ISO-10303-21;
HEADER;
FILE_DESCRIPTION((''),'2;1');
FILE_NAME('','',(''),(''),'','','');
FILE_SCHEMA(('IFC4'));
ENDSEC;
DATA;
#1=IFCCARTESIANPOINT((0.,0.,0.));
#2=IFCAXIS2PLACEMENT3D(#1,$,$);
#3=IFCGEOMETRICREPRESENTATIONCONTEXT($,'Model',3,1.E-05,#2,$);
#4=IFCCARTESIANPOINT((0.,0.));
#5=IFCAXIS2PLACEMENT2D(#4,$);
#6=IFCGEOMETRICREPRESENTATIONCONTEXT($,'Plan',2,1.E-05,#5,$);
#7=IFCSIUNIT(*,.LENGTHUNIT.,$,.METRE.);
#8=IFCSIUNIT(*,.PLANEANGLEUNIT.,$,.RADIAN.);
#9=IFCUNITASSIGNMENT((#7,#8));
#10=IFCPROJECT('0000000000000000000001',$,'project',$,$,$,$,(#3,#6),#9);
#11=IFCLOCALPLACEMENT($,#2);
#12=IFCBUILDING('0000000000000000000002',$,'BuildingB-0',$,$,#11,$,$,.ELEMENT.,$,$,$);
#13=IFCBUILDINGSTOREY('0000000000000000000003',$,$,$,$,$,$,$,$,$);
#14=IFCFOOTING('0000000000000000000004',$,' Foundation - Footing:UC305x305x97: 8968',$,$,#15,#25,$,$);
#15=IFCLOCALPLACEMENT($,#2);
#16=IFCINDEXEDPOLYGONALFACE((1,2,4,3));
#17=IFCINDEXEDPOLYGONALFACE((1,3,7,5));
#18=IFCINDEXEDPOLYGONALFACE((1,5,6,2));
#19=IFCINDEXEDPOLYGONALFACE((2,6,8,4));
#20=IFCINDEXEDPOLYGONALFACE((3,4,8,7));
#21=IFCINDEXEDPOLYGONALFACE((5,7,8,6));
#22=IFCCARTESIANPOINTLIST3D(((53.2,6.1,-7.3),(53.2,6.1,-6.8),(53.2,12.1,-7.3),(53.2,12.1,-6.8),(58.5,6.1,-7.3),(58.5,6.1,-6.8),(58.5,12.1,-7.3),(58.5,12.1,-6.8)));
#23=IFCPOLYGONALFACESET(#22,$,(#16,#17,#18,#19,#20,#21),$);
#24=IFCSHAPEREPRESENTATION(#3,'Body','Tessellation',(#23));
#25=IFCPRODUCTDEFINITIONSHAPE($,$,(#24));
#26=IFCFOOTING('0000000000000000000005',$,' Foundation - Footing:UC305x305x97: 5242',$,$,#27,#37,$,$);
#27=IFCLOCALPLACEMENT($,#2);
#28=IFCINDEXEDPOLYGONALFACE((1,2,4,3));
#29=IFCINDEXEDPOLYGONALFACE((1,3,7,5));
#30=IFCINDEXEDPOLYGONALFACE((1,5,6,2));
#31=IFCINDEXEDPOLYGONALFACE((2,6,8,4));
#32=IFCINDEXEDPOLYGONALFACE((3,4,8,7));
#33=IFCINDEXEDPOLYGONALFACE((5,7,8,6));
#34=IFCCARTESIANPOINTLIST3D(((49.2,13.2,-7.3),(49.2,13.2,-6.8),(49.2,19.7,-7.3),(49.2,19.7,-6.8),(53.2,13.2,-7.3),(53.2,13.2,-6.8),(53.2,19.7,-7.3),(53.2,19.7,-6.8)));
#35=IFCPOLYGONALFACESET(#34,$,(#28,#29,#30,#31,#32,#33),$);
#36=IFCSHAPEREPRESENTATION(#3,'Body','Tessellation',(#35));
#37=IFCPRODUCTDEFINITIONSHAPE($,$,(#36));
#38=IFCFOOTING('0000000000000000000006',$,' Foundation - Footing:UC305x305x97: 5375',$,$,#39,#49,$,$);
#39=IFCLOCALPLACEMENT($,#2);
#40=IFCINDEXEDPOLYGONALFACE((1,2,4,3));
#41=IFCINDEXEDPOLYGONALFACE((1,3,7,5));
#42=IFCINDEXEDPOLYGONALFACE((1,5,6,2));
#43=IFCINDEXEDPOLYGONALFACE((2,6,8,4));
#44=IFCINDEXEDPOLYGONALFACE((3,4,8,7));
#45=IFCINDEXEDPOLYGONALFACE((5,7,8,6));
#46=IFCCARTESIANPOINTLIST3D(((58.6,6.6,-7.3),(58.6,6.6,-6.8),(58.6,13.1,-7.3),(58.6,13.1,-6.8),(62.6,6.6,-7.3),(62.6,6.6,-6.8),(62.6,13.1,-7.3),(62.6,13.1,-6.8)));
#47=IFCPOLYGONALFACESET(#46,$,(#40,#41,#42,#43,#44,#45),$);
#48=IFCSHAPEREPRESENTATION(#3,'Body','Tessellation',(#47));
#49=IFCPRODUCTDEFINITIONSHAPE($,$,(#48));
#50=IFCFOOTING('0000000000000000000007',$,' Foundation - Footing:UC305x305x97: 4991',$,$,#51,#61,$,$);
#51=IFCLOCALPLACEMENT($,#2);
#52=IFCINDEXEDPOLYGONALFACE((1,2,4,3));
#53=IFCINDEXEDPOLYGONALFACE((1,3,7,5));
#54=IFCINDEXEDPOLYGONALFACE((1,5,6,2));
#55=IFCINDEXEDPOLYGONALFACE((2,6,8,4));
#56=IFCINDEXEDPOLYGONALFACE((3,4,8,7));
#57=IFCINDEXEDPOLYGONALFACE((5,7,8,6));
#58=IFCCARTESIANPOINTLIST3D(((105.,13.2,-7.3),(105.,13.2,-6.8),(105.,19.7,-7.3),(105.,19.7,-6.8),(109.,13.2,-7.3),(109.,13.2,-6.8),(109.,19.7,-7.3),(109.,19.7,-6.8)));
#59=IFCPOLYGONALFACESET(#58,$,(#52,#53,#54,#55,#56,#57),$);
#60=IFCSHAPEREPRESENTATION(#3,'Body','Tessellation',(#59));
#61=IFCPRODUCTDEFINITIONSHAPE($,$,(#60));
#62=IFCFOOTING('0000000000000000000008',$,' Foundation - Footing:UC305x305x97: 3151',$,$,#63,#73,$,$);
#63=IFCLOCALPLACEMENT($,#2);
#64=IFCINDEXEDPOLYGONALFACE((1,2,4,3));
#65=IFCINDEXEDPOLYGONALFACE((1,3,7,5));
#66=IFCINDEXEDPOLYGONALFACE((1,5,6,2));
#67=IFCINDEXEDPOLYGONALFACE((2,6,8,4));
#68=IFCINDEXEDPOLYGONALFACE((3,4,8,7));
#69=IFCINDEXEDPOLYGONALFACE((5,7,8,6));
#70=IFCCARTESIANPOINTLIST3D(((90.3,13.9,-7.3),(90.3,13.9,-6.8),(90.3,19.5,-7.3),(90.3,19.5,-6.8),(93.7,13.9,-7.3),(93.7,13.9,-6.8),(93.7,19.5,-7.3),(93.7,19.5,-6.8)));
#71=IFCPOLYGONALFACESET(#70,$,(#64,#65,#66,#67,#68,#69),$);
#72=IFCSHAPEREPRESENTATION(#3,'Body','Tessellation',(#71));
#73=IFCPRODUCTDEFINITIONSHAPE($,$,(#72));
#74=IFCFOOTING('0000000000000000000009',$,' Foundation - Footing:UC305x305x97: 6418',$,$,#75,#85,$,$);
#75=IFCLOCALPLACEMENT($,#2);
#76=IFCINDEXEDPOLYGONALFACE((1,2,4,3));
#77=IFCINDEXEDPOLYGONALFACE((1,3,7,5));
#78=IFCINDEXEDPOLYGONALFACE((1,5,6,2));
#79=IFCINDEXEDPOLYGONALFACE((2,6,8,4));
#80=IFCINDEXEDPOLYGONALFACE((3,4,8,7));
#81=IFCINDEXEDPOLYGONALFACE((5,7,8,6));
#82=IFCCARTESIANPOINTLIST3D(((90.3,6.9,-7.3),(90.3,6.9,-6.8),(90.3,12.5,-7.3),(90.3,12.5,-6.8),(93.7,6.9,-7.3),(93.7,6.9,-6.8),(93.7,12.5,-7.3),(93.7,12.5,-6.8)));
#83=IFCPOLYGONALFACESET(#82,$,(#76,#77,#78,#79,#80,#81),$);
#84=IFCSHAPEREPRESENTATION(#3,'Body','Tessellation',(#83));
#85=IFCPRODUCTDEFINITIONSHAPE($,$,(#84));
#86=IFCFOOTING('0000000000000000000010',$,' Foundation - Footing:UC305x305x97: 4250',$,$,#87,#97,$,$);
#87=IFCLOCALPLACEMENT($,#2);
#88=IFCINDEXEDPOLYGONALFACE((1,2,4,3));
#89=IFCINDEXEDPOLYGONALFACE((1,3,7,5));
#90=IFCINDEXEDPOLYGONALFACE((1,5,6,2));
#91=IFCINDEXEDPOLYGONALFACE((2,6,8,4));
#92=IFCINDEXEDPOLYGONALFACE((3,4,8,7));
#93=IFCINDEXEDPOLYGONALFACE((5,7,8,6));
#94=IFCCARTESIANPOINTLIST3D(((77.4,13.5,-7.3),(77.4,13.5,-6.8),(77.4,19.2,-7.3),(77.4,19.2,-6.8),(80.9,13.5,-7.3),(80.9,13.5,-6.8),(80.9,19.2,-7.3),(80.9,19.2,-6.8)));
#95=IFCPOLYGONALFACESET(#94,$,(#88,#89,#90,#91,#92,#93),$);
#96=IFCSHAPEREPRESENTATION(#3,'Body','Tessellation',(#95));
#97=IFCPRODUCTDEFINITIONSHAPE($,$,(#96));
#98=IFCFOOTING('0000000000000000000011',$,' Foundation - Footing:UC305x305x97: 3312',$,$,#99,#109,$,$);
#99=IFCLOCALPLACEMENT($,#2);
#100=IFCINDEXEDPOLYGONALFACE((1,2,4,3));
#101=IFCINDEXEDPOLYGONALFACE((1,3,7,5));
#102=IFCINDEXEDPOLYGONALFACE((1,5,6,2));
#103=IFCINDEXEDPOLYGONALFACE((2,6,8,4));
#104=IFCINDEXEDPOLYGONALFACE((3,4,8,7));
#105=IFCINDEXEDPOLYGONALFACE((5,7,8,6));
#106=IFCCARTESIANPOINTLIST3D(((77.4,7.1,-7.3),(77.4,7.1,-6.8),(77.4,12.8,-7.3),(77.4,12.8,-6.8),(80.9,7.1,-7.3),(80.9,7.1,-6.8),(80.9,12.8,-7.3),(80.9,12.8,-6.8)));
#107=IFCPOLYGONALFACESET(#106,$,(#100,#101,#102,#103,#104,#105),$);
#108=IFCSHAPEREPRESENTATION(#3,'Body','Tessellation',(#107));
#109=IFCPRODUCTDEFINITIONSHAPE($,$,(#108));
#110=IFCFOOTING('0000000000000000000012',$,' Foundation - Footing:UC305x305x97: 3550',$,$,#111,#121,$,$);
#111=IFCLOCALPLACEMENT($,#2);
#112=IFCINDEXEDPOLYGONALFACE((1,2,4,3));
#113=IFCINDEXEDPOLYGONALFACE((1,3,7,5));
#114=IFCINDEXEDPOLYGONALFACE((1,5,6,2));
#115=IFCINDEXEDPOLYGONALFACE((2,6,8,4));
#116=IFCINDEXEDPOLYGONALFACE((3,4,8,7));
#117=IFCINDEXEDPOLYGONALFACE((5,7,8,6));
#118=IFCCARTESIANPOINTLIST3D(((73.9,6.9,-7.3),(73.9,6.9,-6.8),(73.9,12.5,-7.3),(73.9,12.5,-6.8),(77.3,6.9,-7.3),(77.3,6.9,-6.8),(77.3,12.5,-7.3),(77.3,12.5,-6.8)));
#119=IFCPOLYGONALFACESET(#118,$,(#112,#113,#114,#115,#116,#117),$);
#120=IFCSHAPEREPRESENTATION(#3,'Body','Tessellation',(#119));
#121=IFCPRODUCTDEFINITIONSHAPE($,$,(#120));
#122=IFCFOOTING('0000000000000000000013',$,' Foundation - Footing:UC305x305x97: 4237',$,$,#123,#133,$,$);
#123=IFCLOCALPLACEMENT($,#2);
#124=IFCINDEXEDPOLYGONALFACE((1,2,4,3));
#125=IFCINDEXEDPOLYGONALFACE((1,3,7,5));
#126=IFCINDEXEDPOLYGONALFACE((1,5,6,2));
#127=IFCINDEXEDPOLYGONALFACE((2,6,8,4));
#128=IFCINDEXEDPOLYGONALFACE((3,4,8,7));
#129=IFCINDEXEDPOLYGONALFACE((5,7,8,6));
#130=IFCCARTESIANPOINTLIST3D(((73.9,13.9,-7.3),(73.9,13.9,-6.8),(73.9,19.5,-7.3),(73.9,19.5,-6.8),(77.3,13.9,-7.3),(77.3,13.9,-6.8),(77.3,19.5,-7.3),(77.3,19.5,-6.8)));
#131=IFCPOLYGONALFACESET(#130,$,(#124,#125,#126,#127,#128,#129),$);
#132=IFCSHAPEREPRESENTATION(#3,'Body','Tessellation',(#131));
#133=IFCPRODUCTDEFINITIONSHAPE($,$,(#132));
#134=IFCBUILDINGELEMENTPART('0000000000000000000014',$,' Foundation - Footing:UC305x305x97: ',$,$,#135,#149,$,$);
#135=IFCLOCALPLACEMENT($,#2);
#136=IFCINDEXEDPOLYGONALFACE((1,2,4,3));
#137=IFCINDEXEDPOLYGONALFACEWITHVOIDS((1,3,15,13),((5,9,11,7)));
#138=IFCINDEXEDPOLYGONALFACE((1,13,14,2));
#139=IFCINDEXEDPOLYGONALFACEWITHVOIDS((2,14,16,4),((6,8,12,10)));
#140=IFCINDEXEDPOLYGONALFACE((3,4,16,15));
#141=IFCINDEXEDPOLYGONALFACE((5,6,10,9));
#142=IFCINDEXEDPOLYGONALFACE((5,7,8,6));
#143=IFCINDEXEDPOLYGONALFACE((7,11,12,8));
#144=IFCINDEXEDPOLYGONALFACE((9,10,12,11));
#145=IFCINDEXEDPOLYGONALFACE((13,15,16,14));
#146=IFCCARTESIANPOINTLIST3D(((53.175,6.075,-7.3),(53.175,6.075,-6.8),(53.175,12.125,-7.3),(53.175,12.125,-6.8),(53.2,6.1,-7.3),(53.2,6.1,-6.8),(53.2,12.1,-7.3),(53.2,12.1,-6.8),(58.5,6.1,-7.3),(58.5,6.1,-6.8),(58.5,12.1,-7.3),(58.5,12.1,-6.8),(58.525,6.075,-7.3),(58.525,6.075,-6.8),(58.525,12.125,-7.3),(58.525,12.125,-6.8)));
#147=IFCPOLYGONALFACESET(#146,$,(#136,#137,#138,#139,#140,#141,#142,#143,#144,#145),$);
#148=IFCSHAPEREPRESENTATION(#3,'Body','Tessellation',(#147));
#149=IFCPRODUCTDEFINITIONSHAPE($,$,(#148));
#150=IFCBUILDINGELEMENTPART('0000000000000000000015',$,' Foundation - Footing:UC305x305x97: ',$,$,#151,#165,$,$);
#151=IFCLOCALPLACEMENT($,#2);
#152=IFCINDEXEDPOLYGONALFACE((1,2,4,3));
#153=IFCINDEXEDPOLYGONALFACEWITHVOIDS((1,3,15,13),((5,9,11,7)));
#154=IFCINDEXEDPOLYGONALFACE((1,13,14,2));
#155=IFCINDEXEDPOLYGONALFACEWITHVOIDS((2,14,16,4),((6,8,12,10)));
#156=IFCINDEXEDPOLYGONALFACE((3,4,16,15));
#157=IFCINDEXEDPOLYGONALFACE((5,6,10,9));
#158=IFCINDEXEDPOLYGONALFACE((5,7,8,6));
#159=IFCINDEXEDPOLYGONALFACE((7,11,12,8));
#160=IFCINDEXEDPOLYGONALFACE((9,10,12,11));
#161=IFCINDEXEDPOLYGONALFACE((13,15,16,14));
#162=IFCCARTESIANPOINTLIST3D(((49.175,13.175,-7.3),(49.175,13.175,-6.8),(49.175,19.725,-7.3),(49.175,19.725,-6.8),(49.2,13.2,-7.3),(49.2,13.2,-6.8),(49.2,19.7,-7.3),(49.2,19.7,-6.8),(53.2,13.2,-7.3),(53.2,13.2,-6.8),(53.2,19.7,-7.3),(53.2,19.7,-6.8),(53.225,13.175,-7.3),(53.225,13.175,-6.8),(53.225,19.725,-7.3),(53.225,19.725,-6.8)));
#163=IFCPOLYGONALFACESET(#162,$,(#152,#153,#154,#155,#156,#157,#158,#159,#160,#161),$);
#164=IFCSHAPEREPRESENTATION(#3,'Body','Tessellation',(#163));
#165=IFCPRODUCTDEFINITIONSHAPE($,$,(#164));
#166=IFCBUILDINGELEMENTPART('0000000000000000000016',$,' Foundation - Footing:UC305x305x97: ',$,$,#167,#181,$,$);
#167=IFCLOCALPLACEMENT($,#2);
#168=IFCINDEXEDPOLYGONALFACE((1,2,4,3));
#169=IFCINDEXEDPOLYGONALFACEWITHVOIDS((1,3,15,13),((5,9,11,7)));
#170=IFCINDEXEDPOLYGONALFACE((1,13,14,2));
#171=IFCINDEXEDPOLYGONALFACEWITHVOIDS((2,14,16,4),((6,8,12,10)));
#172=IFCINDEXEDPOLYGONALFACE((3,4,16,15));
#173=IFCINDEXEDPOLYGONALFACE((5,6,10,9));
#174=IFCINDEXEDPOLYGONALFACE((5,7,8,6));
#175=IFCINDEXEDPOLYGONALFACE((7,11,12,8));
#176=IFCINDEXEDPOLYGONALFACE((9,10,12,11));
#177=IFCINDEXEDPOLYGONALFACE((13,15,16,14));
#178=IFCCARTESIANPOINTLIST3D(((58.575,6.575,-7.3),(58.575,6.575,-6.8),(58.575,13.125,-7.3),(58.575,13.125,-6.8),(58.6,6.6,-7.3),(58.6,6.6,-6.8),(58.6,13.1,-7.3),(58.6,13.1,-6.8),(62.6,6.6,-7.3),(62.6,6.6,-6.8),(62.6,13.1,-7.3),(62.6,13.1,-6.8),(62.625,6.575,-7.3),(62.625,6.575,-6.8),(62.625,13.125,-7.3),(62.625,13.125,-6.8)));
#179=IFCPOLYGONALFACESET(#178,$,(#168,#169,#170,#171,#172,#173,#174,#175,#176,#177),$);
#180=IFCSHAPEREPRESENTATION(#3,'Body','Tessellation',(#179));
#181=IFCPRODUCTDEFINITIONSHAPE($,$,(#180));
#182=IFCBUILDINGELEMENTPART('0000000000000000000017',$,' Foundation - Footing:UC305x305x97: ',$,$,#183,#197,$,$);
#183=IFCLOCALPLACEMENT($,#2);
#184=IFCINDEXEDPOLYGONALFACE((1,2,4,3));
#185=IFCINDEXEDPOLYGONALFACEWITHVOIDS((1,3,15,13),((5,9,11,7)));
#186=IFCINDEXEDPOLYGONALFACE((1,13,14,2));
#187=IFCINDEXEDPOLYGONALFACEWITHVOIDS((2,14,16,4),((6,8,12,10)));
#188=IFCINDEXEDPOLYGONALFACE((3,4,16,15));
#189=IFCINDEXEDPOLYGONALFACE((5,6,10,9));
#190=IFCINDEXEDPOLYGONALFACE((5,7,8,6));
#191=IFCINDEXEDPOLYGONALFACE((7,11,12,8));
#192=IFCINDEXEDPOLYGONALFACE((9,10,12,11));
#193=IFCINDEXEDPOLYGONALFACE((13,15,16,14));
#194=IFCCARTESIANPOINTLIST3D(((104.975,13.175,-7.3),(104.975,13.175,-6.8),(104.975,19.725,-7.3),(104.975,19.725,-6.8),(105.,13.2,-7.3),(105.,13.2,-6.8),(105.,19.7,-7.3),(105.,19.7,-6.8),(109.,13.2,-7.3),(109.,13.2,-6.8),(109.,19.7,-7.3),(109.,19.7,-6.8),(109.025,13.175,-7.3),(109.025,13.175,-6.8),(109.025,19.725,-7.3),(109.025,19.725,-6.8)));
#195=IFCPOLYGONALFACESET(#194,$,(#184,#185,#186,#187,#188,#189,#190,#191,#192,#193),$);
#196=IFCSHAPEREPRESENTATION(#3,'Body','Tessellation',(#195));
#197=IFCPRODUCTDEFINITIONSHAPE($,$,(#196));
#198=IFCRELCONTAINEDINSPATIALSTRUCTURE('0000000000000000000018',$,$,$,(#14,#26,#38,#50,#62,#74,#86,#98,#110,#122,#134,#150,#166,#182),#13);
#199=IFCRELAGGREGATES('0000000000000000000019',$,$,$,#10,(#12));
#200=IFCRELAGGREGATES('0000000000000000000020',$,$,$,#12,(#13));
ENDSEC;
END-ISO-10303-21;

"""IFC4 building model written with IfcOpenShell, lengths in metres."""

from ifc_helpers import new_model, si_unit, origin, origin_2d, place, context, project, spatial, polyline, outline, extrude, element, save


model = new_model("IFC4")

# Units and contexts
model_context = context("Model", 3, precision=1e-05, world=origin())
plan_context = context("Plan", 2, precision=1e-05, world=origin_2d())
ifc_project = project(units=[si_unit("LENGTHUNIT", "METRE"), si_unit("PLANEANGLEUNIT", "RADIAN")], contexts=[model_context, plan_context])

# Building, storey
building_placement = place(None, origin())
building = spatial("IfcBuilding", under=ifc_project, at=building_placement, Name="BuildingB-0", CompositionType="ELEMENT")
storey = spatial("IfcBuildingStorey", under=building)

# Footings
element("IfcFooting", 1, inside=storey, Name=" Foundation - Footing:UC305x305x97: 8968", context=model_context, shape_type="SweptSolid", body=[
    extrude(outline(polyline([(58.5, 12.1, -7.3), (53.2, 12.1, -7.3), (53.2, 6.1, -7.3), (58.5, 6.1, -7.3), (58.5, 12.1, -7.3)])), None, (0.0, 0.0, 1.0), 0.5),
])
element("IfcFooting", 2, inside=storey, Name=" Foundation - Footing:UC305x305x97: 5242", context=model_context, shape_type="SweptSolid", body=[
    extrude(outline(polyline([(53.2, 19.7, -7.3), (49.2, 19.7, -7.3), (49.2, 13.2, -7.3), (53.2, 13.2, -7.3), (53.2, 19.7, -7.3)])), None, (0.0, 0.0, 1.0), 0.5),
])
element("IfcFooting", 3, inside=storey, Name=" Foundation - Footing:UC305x305x97: 5375", context=model_context, shape_type="SweptSolid", body=[
    extrude(outline(polyline([(58.6, 13.1, -7.3), (62.6, 13.1, -7.3), (62.6, 6.6, -7.3), (58.6, 6.6, -7.3), (58.6, 13.1, -7.3)])), None, (0.0, 0.0, 1.0), 0.5),
])
element("IfcFooting", 4, inside=storey, Name=" Foundation - Footing:UC305x305x97: 4991", context=model_context, shape_type="SweptSolid", body=[
    extrude(outline(polyline([(109.0, 19.7, -7.3), (105.0, 19.7, -7.3), (105.0, 13.2, -7.3), (109.0, 13.2, -7.3), (109.0, 19.7, -7.3)])), None, (0.0, 0.0, 1.0), 0.5),
])
element("IfcFooting", 5, inside=storey, Name=" Foundation - Footing:UC305x305x97: 3151", context=model_context, shape_type="SweptSolid", body=[
    extrude(outline(polyline([(90.3, 19.5, -7.3), (93.7, 19.5, -7.3), (93.7, 13.9, -7.3), (90.3, 13.9, -7.3), (90.3, 19.5, -7.3)])), None, (0.0, 0.0, 1.0), 0.5),
])
element("IfcFooting", 6, inside=storey, Name=" Foundation - Footing:UC305x305x97: 6418", context=model_context, shape_type="SweptSolid", body=[
    extrude(outline(polyline([(90.3, 12.5, -7.3), (93.7, 12.5, -7.3), (93.7, 6.9, -7.3), (90.3, 6.9, -7.3), (90.3, 12.5, -7.3)])), None, (0.0, 0.0, 1.0), 0.5),
])
element("IfcFooting", 7, inside=storey, Name=" Foundation - Footing:UC305x305x97: 4250", context=model_context, shape_type="SweptSolid", body=[
    extrude(outline(polyline([(77.4, 19.2, -7.3), (80.9, 19.2, -7.3), (80.9, 13.5, -7.3), (77.4, 13.5, -7.3), (77.4, 19.2, -7.3)])), None, (0.0, 0.0, 1.0), 0.5),
])
element("IfcFooting", 8, inside=storey, Name=" Foundation - Footing:UC305x305x97: 3312", context=model_context, shape_type="SweptSolid", body=[
    extrude(outline(polyline([(77.4, 12.8, -7.3), (80.9, 12.8, -7.3), (80.9, 7.1, -7.3), (77.4, 7.1, -7.3), (77.4, 12.8, -7.3)])), None, (0.0, 0.0, 1.0), 0.5),
])
element("IfcFooting", 9, inside=storey, Name=" Foundation - Footing:UC305x305x97: 3550", context=model_context, shape_type="SweptSolid", body=[
    extrude(outline(polyline([(73.9, 12.5, -7.3), (77.3, 12.5, -7.3), (77.3, 6.9, -7.3), (73.9, 6.9, -7.3), (73.9, 12.5, -7.3)])), None, (0.0, 0.0, 1.0), 0.5),
])
element("IfcFooting", 10, inside=storey, Name=" Foundation - Footing:UC305x305x97: 4237", context=model_context, shape_type="SweptSolid", body=[
    extrude(outline(polyline([(73.9, 19.5, -7.3), (77.3, 19.5, -7.3), (77.3, 13.9, -7.3), (73.9, 13.9, -7.3), (73.9, 19.5, -7.3)])), None, (0.0, 0.0, 1.0), 0.5),
])

# Building element parts, openings
building_element_part_1 = element("IfcBuildingElementPart", 11, inside=storey, Name=" Foundation - Footing:UC305x305x97: ", context=model_context, shape_type="SweptSolid", body=[
    extrude(outline(polyline([(58.525, 12.125, -7.3), (53.175, 12.125, -7.3), (53.175, 6.075, -7.3), (58.525, 6.075, -7.3), (58.525, 12.125, -7.3)])), None, (0.0, 0.0, 1.0), 0.5),
])
element("IfcOpeningElement", 12, inside=storey, cuts=building_element_part_1, context=model_context, shape_type="SweptSolid", body=[
    extrude(outline(polyline([(58.5, 12.1, -7.3), (53.2, 12.1, -7.3), (53.2, 6.1, -7.3), (58.5, 6.1, -7.3), (58.5, 12.1, -7.3)])), None, (0.0, 0.0, 1.0), 0.5),
])
building_element_part_2 = element("IfcBuildingElementPart", 13, inside=storey, Name=" Foundation - Footing:UC305x305x97: ", context=model_context, shape_type="SweptSolid", body=[
    extrude(outline(polyline([(53.225, 19.725, -7.3), (49.175, 19.725, -7.3), (49.175, 13.175, -7.3), (53.225, 13.175, -7.3), (53.225, 19.725, -7.3)])), None, (0.0, 0.0, 1.0), 0.5),
])
element("IfcOpeningElement", 14, inside=storey, cuts=building_element_part_2, context=model_context, shape_type="SweptSolid", body=[
    extrude(outline(polyline([(53.2, 19.7, -7.3), (49.2, 19.7, -7.3), (49.2, 13.2, -7.3), (53.2, 13.2, -7.3), (53.2, 19.7, -7.3)])), None, (0.0, 0.0, 1.0), 0.5),
])
building_element_part_3 = element("IfcBuildingElementPart", 15, inside=storey, Name=" Foundation - Footing:UC305x305x97: ", context=model_context, shape_type="SweptSolid", body=[
    extrude(outline(polyline([(58.575, 13.125, -7.3), (62.625, 13.125, -7.3), (62.625, 6.575, -7.3), (58.575, 6.575, -7.3), (58.575, 13.125, -7.3)])), None, (0.0, 0.0, 1.0), 0.5),
])
element("IfcOpeningElement", 16, inside=storey, cuts=building_element_part_3, context=model_context, shape_type="SweptSolid", body=[
    extrude(outline(polyline([(58.6, 13.1, -7.3), (62.6, 13.1, -7.3), (62.6, 6.6, -7.3), (58.6, 6.6, -7.3), (58.6, 13.1, -7.3)])), None, (0.0, 0.0, 1.0), 0.5),
])
building_element_part_4 = element("IfcBuildingElementPart", 17, inside=storey, Name=" Foundation - Footing:UC305x305x97: ", context=model_context, shape_type="SweptSolid", body=[
    extrude(outline(polyline([(109.025, 19.725, -7.3), (104.975, 19.725, -7.3), (104.975, 13.175, -7.3), (109.025, 13.175, -7.3), (109.025, 19.725, -7.3)])), None, (0.0, 0.0, 1.0), 0.5),
])
element("IfcOpeningElement", 18, inside=storey, cuts=building_element_part_4, context=model_context, shape_type="SweptSolid", body=[
    extrude(outline(polyline([(109.0, 19.7, -7.3), (105.0, 19.7, -7.3), (105.0, 13.2, -7.3), (109.0, 13.2, -7.3), (109.0, 19.7, -7.3)])), None, (0.0, 0.0, 1.0), 0.5),
])

save(model, "model.ifc")
